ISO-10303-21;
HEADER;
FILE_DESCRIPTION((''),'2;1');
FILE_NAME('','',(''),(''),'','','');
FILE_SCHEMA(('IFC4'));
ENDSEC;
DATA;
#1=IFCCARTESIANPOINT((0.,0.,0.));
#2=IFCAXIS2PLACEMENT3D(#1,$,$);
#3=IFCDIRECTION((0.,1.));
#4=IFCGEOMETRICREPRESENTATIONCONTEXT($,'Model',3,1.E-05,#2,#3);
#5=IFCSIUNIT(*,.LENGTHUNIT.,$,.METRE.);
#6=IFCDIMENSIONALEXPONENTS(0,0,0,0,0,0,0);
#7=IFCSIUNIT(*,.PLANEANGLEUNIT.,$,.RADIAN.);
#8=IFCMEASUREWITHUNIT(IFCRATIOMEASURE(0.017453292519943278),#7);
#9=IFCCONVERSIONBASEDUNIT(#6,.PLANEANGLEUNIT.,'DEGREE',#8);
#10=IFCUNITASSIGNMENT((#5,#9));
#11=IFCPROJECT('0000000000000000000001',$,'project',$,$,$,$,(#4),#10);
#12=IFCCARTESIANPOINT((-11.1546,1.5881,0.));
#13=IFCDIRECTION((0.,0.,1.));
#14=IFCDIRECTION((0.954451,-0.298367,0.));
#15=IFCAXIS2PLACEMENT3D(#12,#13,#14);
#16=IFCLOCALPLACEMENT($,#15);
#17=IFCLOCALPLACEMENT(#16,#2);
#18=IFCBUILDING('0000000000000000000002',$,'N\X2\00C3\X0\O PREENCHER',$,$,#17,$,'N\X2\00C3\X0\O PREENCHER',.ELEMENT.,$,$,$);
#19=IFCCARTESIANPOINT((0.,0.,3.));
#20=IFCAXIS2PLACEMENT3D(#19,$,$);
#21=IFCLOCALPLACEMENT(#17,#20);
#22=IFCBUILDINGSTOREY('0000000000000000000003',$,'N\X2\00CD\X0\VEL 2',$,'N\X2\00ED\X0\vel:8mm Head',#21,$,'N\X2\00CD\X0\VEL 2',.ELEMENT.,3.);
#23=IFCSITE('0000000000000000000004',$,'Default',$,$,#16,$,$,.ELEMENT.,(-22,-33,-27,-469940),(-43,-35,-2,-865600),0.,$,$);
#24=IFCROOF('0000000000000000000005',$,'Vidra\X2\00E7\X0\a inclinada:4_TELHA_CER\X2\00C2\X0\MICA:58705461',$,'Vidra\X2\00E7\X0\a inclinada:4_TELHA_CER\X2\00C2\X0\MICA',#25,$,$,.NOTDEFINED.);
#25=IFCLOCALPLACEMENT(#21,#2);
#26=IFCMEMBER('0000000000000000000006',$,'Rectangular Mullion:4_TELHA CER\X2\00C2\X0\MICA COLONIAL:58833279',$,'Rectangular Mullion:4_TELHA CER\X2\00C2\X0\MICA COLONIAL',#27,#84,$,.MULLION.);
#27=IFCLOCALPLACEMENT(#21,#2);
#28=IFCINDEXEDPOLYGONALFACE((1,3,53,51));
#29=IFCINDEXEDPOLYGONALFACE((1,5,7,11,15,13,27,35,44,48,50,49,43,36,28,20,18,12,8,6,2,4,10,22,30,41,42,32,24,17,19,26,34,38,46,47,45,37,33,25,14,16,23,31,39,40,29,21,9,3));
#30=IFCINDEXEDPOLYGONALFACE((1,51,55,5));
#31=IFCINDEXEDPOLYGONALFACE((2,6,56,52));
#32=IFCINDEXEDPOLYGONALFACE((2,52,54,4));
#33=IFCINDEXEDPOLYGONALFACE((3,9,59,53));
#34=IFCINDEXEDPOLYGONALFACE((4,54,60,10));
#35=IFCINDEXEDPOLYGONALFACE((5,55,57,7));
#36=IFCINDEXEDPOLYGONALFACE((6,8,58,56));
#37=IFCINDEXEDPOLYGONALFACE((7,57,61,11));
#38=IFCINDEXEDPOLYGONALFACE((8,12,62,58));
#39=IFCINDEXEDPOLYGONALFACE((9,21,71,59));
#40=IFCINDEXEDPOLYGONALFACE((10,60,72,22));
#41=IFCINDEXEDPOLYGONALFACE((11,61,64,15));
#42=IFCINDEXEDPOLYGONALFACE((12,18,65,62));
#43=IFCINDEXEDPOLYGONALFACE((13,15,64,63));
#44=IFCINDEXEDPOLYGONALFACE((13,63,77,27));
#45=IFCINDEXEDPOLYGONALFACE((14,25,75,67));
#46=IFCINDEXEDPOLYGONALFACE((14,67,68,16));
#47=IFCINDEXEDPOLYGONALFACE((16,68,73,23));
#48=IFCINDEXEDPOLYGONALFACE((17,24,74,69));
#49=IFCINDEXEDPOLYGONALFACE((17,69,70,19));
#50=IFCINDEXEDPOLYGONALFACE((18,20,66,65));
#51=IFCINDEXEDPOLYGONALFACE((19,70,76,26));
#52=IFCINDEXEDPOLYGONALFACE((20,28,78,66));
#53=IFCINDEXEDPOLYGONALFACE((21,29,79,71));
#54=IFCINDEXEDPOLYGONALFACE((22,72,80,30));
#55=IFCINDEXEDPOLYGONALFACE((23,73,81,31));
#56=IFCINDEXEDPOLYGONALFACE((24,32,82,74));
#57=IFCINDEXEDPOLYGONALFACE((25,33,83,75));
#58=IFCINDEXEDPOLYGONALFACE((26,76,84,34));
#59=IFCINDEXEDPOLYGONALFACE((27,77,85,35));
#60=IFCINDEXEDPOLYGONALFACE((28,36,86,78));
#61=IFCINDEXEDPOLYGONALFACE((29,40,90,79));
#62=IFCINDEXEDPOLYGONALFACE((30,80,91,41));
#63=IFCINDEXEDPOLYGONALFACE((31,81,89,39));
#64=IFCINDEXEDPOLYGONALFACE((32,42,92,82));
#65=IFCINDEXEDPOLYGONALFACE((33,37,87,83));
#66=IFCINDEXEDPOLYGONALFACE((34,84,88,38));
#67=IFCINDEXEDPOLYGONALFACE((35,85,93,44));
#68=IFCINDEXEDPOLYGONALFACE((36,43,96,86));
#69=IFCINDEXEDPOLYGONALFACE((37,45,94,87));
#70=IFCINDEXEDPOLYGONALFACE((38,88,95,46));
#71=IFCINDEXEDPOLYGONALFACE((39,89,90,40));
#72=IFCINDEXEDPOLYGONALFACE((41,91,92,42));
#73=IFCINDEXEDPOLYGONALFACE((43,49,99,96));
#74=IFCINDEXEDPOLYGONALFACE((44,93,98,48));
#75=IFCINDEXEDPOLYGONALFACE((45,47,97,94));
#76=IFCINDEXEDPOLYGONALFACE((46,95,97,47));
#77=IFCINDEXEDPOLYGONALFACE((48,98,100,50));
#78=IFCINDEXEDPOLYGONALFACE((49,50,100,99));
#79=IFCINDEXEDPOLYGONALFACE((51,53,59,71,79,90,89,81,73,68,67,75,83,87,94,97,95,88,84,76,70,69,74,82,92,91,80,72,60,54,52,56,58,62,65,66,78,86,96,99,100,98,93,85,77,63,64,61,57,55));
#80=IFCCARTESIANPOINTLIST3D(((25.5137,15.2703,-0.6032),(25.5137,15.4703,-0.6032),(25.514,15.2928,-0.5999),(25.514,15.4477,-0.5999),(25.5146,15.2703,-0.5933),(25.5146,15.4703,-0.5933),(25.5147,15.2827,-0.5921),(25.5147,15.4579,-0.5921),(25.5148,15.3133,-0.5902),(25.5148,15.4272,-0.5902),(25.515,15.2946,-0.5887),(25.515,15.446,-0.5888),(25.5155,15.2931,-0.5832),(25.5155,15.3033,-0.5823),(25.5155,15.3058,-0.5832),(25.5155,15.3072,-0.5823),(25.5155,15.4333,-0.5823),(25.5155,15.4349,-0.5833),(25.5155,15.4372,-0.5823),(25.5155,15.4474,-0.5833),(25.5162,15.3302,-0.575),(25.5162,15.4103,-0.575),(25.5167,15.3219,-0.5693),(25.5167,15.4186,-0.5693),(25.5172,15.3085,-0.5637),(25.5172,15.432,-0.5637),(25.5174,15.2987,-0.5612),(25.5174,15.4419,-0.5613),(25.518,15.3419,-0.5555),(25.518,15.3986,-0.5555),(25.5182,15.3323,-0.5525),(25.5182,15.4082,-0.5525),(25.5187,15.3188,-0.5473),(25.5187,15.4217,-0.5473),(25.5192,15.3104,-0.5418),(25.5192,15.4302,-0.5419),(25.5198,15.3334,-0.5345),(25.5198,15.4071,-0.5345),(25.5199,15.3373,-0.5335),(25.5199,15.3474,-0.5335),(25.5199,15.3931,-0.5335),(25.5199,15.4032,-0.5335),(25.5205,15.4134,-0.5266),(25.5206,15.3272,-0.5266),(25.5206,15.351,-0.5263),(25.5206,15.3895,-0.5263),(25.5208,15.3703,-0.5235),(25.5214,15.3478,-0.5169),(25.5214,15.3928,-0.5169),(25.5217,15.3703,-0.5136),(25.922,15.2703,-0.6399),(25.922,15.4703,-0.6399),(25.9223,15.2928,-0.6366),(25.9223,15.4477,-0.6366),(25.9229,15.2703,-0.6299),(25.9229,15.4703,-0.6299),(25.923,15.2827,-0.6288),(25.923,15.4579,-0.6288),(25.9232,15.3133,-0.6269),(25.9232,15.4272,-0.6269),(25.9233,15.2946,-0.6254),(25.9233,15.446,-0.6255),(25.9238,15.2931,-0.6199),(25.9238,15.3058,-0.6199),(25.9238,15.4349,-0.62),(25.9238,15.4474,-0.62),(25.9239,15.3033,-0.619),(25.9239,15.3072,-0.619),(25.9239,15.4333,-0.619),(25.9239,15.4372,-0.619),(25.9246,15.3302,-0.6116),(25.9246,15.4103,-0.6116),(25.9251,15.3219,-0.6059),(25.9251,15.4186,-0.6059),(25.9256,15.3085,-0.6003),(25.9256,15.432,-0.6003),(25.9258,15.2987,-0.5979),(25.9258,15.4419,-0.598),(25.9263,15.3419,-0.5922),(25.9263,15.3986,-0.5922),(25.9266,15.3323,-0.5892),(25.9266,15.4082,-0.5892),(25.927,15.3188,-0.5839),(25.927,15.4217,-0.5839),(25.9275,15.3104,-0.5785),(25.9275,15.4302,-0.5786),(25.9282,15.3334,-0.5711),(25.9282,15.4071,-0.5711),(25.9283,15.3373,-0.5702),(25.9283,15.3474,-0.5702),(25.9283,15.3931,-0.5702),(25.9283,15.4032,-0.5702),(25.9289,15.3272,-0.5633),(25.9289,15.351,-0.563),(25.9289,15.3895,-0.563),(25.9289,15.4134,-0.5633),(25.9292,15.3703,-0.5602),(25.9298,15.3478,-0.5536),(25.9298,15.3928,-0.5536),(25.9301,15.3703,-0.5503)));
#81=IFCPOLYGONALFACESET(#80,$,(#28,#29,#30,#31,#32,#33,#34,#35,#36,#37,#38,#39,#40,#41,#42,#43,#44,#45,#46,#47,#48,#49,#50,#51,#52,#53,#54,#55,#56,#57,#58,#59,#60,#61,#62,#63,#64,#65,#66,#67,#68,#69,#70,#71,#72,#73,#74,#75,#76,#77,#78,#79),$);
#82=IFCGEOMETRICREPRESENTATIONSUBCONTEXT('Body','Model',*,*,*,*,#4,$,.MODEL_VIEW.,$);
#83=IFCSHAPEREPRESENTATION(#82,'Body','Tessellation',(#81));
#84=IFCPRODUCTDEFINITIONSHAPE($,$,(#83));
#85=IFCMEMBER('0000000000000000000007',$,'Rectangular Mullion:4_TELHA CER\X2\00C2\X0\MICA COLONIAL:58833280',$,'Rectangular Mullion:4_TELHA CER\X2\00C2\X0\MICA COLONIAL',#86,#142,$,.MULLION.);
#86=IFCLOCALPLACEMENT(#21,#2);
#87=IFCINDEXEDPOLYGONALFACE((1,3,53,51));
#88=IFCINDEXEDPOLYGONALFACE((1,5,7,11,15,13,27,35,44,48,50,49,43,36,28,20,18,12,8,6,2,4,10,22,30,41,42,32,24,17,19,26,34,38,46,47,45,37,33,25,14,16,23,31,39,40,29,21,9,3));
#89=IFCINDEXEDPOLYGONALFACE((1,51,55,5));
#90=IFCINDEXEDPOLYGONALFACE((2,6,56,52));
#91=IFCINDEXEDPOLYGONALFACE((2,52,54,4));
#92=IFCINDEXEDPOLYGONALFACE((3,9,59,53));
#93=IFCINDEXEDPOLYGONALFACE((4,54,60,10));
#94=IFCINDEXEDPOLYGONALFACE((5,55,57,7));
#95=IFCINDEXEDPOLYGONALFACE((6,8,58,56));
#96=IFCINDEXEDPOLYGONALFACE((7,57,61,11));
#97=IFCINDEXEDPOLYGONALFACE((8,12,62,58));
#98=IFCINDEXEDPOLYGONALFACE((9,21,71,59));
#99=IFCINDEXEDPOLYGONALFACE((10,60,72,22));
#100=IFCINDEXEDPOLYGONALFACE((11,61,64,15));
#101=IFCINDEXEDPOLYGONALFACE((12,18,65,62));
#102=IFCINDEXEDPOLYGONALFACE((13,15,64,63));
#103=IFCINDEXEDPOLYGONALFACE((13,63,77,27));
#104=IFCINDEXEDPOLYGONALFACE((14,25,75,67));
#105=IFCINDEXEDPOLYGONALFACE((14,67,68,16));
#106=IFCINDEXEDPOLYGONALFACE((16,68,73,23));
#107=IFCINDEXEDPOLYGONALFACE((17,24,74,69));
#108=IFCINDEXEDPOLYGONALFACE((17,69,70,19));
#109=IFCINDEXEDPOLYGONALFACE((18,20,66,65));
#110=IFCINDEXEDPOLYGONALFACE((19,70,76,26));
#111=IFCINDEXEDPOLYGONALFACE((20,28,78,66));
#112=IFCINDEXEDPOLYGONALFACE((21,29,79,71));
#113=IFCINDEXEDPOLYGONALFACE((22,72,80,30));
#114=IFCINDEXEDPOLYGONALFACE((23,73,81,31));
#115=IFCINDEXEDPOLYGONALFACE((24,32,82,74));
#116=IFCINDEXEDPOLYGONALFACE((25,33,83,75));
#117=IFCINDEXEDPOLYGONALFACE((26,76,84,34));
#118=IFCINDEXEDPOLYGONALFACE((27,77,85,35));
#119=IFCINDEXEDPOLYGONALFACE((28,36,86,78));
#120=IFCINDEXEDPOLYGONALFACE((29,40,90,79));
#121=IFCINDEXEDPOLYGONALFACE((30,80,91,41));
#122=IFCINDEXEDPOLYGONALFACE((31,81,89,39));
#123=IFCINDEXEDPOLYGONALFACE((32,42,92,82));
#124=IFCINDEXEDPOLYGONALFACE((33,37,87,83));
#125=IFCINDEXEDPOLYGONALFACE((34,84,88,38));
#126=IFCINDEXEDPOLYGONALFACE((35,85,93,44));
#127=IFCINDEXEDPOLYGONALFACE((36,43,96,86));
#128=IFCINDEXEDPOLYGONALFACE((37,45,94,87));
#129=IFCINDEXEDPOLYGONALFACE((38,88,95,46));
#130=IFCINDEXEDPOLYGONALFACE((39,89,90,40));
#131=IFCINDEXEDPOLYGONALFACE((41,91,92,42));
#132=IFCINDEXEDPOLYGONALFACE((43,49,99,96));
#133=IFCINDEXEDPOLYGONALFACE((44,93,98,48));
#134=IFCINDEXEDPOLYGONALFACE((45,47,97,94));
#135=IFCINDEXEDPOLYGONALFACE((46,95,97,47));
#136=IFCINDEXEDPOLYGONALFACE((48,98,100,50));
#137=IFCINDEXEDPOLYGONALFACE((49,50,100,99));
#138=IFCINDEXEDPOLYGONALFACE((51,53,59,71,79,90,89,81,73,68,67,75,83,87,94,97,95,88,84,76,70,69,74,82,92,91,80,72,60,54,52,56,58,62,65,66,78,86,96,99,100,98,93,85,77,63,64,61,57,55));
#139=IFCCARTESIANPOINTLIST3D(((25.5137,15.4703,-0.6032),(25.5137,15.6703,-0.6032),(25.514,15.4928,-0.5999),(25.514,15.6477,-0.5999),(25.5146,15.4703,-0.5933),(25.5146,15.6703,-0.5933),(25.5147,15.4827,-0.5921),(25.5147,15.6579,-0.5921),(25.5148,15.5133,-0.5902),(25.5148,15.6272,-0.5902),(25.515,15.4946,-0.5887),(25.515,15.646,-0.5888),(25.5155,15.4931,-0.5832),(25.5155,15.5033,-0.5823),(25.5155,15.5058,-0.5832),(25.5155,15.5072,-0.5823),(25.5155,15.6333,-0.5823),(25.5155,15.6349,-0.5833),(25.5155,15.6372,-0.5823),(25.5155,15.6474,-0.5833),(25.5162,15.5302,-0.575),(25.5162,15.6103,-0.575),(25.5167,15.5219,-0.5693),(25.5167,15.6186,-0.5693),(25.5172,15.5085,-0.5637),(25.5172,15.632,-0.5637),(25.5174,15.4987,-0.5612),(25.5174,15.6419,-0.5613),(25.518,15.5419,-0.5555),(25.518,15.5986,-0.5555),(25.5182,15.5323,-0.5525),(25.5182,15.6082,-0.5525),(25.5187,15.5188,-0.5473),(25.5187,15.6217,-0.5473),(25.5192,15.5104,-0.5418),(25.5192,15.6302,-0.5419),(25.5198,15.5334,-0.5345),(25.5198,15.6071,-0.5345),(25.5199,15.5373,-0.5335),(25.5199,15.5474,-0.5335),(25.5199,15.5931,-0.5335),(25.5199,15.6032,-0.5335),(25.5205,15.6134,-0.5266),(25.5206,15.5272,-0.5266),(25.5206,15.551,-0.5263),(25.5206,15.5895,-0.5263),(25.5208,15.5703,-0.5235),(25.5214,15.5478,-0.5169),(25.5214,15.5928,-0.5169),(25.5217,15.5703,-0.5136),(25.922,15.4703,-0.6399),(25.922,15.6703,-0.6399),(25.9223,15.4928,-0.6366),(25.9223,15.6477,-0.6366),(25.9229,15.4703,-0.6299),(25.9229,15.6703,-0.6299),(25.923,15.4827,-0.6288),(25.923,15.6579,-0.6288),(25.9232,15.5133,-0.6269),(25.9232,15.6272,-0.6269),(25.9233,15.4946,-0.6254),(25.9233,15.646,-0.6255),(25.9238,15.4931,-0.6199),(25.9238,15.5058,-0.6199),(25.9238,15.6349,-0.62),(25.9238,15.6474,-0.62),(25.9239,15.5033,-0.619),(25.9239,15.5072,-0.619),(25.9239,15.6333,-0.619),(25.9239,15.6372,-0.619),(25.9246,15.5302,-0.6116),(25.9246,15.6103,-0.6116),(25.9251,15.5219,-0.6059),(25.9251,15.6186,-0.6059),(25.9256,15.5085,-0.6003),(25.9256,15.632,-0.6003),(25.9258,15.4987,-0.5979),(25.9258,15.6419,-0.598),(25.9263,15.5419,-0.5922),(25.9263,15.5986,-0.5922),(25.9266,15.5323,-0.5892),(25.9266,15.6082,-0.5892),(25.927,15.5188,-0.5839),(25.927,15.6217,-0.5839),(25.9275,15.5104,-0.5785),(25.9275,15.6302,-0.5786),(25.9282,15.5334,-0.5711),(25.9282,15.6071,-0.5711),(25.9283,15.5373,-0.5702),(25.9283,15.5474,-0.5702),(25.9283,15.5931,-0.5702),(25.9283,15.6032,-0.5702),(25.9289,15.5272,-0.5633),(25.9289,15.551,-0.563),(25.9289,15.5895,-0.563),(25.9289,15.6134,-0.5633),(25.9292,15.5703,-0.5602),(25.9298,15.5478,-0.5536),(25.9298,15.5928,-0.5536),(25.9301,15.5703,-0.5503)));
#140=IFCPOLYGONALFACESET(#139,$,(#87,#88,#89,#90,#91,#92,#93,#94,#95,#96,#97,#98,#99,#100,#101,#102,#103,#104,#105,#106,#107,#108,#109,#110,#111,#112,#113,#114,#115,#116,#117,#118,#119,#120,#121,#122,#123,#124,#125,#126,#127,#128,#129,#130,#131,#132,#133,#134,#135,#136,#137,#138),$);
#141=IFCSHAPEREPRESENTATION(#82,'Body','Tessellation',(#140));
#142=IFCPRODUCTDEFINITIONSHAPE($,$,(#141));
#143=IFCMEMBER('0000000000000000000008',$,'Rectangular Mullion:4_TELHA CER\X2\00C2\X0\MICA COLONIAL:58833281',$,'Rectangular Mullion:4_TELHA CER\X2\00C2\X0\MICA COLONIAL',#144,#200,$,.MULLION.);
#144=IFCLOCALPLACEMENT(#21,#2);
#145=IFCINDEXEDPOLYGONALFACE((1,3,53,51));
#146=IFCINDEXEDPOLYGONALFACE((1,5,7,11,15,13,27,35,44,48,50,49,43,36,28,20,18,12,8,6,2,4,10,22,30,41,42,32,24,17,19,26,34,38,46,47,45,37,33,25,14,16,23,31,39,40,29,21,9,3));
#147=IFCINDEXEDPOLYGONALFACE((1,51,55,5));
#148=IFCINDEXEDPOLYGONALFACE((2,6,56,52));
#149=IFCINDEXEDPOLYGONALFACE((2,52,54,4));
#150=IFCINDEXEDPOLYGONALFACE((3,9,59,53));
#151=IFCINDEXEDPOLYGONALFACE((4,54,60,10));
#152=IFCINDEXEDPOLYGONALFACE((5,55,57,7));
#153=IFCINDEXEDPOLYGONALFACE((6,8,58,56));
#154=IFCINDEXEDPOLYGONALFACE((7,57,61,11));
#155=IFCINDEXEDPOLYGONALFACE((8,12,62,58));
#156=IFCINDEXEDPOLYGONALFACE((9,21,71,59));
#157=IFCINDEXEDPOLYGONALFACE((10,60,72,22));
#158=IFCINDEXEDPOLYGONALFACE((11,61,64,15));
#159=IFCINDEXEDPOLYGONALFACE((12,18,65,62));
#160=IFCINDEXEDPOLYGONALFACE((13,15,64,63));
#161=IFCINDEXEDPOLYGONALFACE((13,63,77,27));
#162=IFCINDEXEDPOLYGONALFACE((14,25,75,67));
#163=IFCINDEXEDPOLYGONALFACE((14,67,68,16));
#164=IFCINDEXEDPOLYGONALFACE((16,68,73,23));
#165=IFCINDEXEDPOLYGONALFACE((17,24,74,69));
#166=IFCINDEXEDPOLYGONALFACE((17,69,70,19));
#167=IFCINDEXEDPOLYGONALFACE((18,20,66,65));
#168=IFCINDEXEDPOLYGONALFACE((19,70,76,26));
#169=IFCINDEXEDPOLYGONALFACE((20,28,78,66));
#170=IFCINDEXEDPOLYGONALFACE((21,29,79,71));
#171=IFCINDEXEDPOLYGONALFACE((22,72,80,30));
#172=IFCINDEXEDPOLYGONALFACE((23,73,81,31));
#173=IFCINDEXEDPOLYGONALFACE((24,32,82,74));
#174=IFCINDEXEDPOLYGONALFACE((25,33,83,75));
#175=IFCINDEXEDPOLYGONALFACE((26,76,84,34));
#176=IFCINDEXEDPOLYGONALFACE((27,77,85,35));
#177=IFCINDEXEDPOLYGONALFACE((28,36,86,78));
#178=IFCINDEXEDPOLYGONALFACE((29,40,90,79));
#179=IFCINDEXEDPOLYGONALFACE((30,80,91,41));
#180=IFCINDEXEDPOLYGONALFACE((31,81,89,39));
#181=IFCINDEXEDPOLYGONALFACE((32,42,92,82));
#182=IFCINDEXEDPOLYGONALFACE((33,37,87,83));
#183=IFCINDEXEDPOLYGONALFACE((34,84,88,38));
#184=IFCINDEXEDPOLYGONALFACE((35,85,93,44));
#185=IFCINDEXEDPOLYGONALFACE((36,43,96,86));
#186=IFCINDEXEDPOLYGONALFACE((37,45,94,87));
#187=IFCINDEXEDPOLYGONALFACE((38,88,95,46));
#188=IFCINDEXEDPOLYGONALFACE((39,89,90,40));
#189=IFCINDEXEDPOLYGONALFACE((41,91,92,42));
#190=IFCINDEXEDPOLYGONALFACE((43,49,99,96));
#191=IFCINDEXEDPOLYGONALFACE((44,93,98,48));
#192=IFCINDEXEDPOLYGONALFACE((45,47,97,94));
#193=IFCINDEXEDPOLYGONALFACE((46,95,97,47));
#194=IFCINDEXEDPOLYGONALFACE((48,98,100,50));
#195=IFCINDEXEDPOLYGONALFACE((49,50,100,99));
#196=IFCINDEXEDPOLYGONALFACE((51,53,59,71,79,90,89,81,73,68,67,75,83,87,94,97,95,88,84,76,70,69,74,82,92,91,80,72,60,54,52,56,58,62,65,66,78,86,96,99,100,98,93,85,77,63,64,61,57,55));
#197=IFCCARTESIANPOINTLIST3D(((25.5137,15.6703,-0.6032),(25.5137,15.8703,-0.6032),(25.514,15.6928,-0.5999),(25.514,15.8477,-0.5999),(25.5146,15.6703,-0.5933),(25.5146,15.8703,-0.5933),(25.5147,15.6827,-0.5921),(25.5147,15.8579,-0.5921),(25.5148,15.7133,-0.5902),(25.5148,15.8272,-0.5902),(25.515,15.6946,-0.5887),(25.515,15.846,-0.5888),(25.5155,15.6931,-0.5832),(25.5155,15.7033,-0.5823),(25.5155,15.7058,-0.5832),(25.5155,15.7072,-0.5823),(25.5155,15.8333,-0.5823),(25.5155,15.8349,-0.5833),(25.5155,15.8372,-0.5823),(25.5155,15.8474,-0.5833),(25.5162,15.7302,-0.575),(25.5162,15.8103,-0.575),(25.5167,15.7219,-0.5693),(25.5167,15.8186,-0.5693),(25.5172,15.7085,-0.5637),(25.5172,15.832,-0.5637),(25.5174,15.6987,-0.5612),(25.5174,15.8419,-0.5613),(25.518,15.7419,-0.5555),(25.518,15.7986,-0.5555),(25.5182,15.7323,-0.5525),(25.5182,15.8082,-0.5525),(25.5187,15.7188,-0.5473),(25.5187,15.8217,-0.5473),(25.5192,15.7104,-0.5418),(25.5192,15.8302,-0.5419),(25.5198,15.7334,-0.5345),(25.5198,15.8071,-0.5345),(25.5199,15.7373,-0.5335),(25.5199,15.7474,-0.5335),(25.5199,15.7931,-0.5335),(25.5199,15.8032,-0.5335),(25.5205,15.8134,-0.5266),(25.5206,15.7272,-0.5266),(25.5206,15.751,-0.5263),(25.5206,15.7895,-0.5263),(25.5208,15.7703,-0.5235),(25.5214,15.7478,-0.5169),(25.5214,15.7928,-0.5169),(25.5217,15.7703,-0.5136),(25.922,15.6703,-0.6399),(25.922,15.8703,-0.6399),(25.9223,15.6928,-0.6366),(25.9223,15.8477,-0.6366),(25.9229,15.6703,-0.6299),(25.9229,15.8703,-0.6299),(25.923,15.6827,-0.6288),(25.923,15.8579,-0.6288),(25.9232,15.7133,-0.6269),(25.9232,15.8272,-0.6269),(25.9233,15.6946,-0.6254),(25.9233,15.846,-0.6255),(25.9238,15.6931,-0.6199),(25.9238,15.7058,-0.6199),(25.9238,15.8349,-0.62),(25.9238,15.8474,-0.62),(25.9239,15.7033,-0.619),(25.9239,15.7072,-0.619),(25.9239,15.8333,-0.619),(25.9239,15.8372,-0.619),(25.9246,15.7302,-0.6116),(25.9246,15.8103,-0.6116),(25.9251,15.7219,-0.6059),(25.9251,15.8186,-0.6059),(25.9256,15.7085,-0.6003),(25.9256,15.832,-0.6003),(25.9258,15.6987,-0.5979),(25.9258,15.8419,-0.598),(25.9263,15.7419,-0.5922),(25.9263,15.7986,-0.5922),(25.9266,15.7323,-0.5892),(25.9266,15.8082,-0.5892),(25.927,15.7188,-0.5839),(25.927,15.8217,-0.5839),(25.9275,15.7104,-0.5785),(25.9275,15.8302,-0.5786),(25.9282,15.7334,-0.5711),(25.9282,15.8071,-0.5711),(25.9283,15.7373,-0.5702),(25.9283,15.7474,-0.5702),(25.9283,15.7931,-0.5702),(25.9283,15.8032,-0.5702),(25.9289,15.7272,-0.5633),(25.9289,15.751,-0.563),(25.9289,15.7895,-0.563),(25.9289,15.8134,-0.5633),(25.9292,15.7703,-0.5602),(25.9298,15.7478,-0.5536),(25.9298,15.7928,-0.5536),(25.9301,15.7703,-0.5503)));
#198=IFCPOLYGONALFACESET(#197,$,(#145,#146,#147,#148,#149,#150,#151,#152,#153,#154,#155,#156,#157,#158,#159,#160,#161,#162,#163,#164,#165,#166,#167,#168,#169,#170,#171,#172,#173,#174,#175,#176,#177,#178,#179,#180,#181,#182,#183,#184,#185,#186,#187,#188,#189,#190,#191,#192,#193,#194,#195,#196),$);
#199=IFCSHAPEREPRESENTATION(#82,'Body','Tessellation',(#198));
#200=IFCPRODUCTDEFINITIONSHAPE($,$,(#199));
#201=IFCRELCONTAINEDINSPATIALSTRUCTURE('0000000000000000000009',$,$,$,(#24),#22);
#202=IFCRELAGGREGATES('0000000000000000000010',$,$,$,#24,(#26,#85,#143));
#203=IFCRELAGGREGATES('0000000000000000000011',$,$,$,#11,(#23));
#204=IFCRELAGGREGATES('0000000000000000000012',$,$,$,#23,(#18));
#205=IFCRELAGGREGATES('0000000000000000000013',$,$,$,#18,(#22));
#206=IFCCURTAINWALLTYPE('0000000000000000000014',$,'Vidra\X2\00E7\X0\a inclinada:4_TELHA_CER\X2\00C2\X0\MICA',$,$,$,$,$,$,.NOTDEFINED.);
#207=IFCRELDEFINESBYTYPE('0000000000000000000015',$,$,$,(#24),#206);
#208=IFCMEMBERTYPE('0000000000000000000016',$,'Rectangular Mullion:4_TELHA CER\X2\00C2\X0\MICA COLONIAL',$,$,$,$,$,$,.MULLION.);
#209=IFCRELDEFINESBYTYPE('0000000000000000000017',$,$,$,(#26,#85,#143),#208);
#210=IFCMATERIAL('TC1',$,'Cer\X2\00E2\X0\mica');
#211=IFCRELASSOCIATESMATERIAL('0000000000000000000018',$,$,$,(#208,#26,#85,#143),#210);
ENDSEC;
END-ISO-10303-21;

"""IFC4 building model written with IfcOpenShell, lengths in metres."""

from ifc_helpers import new_model, entity, si_unit, converted_unit, direction, frame, origin, place, context, subcontext, project, spatial, line, arc, indexed_curve, outline, extrude, source, transform, mapped, material, type_object, type_shapes, element, aggregate, save


model = new_model("IFC4")

# Units and contexts
model_context = context("Model", 3, precision=1e-05, world=origin(), true_north=direction((0.0, 1.0)))
body_context = subcontext(model_context, "Body", "Model", "MODEL_VIEW")
ifc_project = project(units=[si_unit("LENGTHUNIT", "METRE"), converted_unit("PLANEANGLEUNIT", "DEGREE", entity("IfcRatioMeasure", 0.017453292519943278), si_unit("PLANEANGLEUNIT", "RADIAN"), dimensions=[0, 0, 0, 0, 0, 0, 0])], contexts=[model_context])

# Site, building, storey
site_placement = place(None, frame((-11.1546, 1.5881, 0.0), z_axis=(0.0, 0.0, 1.0), x_axis=(0.954451, -0.298367, 0.0)))
site = spatial("IfcSite", under=ifc_project, at=site_placement, Name="Default", CompositionType="ELEMENT", RefLatitude=(-22, -33, -27, -469940), RefLongitude=(-43, -35, -2, -865600), RefElevation=0.0)
building_placement = place(site_placement, origin())
building = spatial("IfcBuilding", under=site, at=building_placement, Name="NÃO PREENCHER", LongName="NÃO PREENCHER", CompositionType="ELEMENT")
storey_placement = place(building_placement, frame((0.0, 0.0, 3.0)))
storey = spatial("IfcBuildingStorey", under=building, at=storey_placement, Name="NÍVEL 2", ObjectType="Nível:8mm Head", LongName="NÍVEL 2", CompositionType="ELEMENT", Elevation=3.0)

# Roof, members
curtain_wall_type = type_object("IfcCurtainWallType", Name="Vidraça inclinada:4_TELHA_CERÂMICA", PredefinedType="NOTDEFINED")
roof_placement = place(storey_placement, frame((0.0, 0.0, -3.0)))
roof = element("IfcRoof", 1, at=roof_placement, inside=storey, type_object=curtain_wall_type, Name="Vidraça inclinada:4_TELHA_CERÂMICA:58705461", ObjectType="Vidraça inclinada:4_TELHA_CERÂMICA", PredefinedType="NOTDEFINED")
ifc_material = material(Name="TC1", Category="Cerâmica")
member_type = type_object("IfcMemberType", Name="Rectangular Mullion:4_TELHA CERÂMICA COLONIAL", PredefinedType="MULLION", material=ifc_material)
shared_shape = source(origin(), body_context, "Body", "SweptSolid", [
    extrude(outline(indexed_curve([(-0.029, -0.1), (-0.019, -0.1), (-0.0164, -0.0815), (-0.0089, -0.0645), (-0.0089, -0.0771), (0.061, 0.0), (-0.009, 0.0771), (-0.009, 0.0646), (-0.0165, 0.0816), (-0.019, 0.1), (-0.029, 0.1), (-0.0089, 0.0479), (0.041, 0.0229), (0.041, 0.0329), (0.0131, 0.0425), (-0.008, 0.0631), (-0.008, 0.067), (0.051, 0.0), (-0.008, -0.067), (-0.008, -0.0631), (0.0131, -0.0425), (0.041, -0.0329), (0.041, -0.0229), (-0.0089, -0.0479)], segments=[line(1, 2), arc(2, 3, 4), line(4, 5), arc(5, 6, 7), line(7, 8), arc(8, 9, 10), line(10, 11), arc(11, 12, 13), line(13, 14), arc(14, 15, 16), line(16, 17), arc(17, 18, 19), line(19, 20), arc(20, 21, 22), line(22, 23), arc(23, 24, 1)], self_intersect=False)), frame((0.0, -0.029, -0.41), z_axis=(0.0, 0.0, 1.0), x_axis=(0.0, -1.0, 0.0)), (0.0, 0.0, 1.0), 0.41),
])
type_shapes(member_type, [shared_shape])
member_1_placement = place(roof_placement, frame((25.5137, 15.3703, 2.3968), z_axis=(-0.99599, 0.0, 0.089469), x_axis=(0.0, 1.0, 0.0)))
member_1 = element("IfcMember", 2, at=member_1_placement, type_object=member_type, material=ifc_material, Name="Rectangular Mullion:4_TELHA CERÂMICA COLONIAL:58833279", ObjectType="Rectangular Mullion:4_TELHA CERÂMICA COLONIAL", PredefinedType="MULLION", context=body_context, shape_type="MappedRepresentation", body=[
    mapped(shared_shape, transform((0.0, 0.0, 0.0), scale=1.0)),
])
member_2_placement = place(roof_placement, frame((25.5137, 15.5703, 2.3968), z_axis=(-0.99599, 0.0, 0.089469), x_axis=(0.0, 1.0, 0.0)))
member_2 = element("IfcMember", 3, at=member_2_placement, type_object=member_type, material=ifc_material, Name="Rectangular Mullion:4_TELHA CERÂMICA COLONIAL:58833280", ObjectType="Rectangular Mullion:4_TELHA CERÂMICA COLONIAL", PredefinedType="MULLION", context=body_context, shape_type="MappedRepresentation", body=[
    mapped(shared_shape, transform((0.0, 0.0, 0.0), scale=1.0)),
])
member_3_placement = place(roof_placement, frame((25.5137, 15.7703, 2.3968), z_axis=(-0.99599, 0.0, 0.089469), x_axis=(0.0, 1.0, 0.0)))
member_3 = element("IfcMember", 4, at=member_3_placement, type_object=member_type, material=ifc_material, Name="Rectangular Mullion:4_TELHA CERÂMICA COLONIAL:58833281", ObjectType="Rectangular Mullion:4_TELHA CERÂMICA COLONIAL", PredefinedType="MULLION", context=body_context, shape_type="MappedRepresentation", body=[
    mapped(shared_shape, transform((0.0, 0.0, 0.0), scale=1.0)),
])
aggregate(roof, [member_1, member_2, member_3])

save(model, "model.ifc")
